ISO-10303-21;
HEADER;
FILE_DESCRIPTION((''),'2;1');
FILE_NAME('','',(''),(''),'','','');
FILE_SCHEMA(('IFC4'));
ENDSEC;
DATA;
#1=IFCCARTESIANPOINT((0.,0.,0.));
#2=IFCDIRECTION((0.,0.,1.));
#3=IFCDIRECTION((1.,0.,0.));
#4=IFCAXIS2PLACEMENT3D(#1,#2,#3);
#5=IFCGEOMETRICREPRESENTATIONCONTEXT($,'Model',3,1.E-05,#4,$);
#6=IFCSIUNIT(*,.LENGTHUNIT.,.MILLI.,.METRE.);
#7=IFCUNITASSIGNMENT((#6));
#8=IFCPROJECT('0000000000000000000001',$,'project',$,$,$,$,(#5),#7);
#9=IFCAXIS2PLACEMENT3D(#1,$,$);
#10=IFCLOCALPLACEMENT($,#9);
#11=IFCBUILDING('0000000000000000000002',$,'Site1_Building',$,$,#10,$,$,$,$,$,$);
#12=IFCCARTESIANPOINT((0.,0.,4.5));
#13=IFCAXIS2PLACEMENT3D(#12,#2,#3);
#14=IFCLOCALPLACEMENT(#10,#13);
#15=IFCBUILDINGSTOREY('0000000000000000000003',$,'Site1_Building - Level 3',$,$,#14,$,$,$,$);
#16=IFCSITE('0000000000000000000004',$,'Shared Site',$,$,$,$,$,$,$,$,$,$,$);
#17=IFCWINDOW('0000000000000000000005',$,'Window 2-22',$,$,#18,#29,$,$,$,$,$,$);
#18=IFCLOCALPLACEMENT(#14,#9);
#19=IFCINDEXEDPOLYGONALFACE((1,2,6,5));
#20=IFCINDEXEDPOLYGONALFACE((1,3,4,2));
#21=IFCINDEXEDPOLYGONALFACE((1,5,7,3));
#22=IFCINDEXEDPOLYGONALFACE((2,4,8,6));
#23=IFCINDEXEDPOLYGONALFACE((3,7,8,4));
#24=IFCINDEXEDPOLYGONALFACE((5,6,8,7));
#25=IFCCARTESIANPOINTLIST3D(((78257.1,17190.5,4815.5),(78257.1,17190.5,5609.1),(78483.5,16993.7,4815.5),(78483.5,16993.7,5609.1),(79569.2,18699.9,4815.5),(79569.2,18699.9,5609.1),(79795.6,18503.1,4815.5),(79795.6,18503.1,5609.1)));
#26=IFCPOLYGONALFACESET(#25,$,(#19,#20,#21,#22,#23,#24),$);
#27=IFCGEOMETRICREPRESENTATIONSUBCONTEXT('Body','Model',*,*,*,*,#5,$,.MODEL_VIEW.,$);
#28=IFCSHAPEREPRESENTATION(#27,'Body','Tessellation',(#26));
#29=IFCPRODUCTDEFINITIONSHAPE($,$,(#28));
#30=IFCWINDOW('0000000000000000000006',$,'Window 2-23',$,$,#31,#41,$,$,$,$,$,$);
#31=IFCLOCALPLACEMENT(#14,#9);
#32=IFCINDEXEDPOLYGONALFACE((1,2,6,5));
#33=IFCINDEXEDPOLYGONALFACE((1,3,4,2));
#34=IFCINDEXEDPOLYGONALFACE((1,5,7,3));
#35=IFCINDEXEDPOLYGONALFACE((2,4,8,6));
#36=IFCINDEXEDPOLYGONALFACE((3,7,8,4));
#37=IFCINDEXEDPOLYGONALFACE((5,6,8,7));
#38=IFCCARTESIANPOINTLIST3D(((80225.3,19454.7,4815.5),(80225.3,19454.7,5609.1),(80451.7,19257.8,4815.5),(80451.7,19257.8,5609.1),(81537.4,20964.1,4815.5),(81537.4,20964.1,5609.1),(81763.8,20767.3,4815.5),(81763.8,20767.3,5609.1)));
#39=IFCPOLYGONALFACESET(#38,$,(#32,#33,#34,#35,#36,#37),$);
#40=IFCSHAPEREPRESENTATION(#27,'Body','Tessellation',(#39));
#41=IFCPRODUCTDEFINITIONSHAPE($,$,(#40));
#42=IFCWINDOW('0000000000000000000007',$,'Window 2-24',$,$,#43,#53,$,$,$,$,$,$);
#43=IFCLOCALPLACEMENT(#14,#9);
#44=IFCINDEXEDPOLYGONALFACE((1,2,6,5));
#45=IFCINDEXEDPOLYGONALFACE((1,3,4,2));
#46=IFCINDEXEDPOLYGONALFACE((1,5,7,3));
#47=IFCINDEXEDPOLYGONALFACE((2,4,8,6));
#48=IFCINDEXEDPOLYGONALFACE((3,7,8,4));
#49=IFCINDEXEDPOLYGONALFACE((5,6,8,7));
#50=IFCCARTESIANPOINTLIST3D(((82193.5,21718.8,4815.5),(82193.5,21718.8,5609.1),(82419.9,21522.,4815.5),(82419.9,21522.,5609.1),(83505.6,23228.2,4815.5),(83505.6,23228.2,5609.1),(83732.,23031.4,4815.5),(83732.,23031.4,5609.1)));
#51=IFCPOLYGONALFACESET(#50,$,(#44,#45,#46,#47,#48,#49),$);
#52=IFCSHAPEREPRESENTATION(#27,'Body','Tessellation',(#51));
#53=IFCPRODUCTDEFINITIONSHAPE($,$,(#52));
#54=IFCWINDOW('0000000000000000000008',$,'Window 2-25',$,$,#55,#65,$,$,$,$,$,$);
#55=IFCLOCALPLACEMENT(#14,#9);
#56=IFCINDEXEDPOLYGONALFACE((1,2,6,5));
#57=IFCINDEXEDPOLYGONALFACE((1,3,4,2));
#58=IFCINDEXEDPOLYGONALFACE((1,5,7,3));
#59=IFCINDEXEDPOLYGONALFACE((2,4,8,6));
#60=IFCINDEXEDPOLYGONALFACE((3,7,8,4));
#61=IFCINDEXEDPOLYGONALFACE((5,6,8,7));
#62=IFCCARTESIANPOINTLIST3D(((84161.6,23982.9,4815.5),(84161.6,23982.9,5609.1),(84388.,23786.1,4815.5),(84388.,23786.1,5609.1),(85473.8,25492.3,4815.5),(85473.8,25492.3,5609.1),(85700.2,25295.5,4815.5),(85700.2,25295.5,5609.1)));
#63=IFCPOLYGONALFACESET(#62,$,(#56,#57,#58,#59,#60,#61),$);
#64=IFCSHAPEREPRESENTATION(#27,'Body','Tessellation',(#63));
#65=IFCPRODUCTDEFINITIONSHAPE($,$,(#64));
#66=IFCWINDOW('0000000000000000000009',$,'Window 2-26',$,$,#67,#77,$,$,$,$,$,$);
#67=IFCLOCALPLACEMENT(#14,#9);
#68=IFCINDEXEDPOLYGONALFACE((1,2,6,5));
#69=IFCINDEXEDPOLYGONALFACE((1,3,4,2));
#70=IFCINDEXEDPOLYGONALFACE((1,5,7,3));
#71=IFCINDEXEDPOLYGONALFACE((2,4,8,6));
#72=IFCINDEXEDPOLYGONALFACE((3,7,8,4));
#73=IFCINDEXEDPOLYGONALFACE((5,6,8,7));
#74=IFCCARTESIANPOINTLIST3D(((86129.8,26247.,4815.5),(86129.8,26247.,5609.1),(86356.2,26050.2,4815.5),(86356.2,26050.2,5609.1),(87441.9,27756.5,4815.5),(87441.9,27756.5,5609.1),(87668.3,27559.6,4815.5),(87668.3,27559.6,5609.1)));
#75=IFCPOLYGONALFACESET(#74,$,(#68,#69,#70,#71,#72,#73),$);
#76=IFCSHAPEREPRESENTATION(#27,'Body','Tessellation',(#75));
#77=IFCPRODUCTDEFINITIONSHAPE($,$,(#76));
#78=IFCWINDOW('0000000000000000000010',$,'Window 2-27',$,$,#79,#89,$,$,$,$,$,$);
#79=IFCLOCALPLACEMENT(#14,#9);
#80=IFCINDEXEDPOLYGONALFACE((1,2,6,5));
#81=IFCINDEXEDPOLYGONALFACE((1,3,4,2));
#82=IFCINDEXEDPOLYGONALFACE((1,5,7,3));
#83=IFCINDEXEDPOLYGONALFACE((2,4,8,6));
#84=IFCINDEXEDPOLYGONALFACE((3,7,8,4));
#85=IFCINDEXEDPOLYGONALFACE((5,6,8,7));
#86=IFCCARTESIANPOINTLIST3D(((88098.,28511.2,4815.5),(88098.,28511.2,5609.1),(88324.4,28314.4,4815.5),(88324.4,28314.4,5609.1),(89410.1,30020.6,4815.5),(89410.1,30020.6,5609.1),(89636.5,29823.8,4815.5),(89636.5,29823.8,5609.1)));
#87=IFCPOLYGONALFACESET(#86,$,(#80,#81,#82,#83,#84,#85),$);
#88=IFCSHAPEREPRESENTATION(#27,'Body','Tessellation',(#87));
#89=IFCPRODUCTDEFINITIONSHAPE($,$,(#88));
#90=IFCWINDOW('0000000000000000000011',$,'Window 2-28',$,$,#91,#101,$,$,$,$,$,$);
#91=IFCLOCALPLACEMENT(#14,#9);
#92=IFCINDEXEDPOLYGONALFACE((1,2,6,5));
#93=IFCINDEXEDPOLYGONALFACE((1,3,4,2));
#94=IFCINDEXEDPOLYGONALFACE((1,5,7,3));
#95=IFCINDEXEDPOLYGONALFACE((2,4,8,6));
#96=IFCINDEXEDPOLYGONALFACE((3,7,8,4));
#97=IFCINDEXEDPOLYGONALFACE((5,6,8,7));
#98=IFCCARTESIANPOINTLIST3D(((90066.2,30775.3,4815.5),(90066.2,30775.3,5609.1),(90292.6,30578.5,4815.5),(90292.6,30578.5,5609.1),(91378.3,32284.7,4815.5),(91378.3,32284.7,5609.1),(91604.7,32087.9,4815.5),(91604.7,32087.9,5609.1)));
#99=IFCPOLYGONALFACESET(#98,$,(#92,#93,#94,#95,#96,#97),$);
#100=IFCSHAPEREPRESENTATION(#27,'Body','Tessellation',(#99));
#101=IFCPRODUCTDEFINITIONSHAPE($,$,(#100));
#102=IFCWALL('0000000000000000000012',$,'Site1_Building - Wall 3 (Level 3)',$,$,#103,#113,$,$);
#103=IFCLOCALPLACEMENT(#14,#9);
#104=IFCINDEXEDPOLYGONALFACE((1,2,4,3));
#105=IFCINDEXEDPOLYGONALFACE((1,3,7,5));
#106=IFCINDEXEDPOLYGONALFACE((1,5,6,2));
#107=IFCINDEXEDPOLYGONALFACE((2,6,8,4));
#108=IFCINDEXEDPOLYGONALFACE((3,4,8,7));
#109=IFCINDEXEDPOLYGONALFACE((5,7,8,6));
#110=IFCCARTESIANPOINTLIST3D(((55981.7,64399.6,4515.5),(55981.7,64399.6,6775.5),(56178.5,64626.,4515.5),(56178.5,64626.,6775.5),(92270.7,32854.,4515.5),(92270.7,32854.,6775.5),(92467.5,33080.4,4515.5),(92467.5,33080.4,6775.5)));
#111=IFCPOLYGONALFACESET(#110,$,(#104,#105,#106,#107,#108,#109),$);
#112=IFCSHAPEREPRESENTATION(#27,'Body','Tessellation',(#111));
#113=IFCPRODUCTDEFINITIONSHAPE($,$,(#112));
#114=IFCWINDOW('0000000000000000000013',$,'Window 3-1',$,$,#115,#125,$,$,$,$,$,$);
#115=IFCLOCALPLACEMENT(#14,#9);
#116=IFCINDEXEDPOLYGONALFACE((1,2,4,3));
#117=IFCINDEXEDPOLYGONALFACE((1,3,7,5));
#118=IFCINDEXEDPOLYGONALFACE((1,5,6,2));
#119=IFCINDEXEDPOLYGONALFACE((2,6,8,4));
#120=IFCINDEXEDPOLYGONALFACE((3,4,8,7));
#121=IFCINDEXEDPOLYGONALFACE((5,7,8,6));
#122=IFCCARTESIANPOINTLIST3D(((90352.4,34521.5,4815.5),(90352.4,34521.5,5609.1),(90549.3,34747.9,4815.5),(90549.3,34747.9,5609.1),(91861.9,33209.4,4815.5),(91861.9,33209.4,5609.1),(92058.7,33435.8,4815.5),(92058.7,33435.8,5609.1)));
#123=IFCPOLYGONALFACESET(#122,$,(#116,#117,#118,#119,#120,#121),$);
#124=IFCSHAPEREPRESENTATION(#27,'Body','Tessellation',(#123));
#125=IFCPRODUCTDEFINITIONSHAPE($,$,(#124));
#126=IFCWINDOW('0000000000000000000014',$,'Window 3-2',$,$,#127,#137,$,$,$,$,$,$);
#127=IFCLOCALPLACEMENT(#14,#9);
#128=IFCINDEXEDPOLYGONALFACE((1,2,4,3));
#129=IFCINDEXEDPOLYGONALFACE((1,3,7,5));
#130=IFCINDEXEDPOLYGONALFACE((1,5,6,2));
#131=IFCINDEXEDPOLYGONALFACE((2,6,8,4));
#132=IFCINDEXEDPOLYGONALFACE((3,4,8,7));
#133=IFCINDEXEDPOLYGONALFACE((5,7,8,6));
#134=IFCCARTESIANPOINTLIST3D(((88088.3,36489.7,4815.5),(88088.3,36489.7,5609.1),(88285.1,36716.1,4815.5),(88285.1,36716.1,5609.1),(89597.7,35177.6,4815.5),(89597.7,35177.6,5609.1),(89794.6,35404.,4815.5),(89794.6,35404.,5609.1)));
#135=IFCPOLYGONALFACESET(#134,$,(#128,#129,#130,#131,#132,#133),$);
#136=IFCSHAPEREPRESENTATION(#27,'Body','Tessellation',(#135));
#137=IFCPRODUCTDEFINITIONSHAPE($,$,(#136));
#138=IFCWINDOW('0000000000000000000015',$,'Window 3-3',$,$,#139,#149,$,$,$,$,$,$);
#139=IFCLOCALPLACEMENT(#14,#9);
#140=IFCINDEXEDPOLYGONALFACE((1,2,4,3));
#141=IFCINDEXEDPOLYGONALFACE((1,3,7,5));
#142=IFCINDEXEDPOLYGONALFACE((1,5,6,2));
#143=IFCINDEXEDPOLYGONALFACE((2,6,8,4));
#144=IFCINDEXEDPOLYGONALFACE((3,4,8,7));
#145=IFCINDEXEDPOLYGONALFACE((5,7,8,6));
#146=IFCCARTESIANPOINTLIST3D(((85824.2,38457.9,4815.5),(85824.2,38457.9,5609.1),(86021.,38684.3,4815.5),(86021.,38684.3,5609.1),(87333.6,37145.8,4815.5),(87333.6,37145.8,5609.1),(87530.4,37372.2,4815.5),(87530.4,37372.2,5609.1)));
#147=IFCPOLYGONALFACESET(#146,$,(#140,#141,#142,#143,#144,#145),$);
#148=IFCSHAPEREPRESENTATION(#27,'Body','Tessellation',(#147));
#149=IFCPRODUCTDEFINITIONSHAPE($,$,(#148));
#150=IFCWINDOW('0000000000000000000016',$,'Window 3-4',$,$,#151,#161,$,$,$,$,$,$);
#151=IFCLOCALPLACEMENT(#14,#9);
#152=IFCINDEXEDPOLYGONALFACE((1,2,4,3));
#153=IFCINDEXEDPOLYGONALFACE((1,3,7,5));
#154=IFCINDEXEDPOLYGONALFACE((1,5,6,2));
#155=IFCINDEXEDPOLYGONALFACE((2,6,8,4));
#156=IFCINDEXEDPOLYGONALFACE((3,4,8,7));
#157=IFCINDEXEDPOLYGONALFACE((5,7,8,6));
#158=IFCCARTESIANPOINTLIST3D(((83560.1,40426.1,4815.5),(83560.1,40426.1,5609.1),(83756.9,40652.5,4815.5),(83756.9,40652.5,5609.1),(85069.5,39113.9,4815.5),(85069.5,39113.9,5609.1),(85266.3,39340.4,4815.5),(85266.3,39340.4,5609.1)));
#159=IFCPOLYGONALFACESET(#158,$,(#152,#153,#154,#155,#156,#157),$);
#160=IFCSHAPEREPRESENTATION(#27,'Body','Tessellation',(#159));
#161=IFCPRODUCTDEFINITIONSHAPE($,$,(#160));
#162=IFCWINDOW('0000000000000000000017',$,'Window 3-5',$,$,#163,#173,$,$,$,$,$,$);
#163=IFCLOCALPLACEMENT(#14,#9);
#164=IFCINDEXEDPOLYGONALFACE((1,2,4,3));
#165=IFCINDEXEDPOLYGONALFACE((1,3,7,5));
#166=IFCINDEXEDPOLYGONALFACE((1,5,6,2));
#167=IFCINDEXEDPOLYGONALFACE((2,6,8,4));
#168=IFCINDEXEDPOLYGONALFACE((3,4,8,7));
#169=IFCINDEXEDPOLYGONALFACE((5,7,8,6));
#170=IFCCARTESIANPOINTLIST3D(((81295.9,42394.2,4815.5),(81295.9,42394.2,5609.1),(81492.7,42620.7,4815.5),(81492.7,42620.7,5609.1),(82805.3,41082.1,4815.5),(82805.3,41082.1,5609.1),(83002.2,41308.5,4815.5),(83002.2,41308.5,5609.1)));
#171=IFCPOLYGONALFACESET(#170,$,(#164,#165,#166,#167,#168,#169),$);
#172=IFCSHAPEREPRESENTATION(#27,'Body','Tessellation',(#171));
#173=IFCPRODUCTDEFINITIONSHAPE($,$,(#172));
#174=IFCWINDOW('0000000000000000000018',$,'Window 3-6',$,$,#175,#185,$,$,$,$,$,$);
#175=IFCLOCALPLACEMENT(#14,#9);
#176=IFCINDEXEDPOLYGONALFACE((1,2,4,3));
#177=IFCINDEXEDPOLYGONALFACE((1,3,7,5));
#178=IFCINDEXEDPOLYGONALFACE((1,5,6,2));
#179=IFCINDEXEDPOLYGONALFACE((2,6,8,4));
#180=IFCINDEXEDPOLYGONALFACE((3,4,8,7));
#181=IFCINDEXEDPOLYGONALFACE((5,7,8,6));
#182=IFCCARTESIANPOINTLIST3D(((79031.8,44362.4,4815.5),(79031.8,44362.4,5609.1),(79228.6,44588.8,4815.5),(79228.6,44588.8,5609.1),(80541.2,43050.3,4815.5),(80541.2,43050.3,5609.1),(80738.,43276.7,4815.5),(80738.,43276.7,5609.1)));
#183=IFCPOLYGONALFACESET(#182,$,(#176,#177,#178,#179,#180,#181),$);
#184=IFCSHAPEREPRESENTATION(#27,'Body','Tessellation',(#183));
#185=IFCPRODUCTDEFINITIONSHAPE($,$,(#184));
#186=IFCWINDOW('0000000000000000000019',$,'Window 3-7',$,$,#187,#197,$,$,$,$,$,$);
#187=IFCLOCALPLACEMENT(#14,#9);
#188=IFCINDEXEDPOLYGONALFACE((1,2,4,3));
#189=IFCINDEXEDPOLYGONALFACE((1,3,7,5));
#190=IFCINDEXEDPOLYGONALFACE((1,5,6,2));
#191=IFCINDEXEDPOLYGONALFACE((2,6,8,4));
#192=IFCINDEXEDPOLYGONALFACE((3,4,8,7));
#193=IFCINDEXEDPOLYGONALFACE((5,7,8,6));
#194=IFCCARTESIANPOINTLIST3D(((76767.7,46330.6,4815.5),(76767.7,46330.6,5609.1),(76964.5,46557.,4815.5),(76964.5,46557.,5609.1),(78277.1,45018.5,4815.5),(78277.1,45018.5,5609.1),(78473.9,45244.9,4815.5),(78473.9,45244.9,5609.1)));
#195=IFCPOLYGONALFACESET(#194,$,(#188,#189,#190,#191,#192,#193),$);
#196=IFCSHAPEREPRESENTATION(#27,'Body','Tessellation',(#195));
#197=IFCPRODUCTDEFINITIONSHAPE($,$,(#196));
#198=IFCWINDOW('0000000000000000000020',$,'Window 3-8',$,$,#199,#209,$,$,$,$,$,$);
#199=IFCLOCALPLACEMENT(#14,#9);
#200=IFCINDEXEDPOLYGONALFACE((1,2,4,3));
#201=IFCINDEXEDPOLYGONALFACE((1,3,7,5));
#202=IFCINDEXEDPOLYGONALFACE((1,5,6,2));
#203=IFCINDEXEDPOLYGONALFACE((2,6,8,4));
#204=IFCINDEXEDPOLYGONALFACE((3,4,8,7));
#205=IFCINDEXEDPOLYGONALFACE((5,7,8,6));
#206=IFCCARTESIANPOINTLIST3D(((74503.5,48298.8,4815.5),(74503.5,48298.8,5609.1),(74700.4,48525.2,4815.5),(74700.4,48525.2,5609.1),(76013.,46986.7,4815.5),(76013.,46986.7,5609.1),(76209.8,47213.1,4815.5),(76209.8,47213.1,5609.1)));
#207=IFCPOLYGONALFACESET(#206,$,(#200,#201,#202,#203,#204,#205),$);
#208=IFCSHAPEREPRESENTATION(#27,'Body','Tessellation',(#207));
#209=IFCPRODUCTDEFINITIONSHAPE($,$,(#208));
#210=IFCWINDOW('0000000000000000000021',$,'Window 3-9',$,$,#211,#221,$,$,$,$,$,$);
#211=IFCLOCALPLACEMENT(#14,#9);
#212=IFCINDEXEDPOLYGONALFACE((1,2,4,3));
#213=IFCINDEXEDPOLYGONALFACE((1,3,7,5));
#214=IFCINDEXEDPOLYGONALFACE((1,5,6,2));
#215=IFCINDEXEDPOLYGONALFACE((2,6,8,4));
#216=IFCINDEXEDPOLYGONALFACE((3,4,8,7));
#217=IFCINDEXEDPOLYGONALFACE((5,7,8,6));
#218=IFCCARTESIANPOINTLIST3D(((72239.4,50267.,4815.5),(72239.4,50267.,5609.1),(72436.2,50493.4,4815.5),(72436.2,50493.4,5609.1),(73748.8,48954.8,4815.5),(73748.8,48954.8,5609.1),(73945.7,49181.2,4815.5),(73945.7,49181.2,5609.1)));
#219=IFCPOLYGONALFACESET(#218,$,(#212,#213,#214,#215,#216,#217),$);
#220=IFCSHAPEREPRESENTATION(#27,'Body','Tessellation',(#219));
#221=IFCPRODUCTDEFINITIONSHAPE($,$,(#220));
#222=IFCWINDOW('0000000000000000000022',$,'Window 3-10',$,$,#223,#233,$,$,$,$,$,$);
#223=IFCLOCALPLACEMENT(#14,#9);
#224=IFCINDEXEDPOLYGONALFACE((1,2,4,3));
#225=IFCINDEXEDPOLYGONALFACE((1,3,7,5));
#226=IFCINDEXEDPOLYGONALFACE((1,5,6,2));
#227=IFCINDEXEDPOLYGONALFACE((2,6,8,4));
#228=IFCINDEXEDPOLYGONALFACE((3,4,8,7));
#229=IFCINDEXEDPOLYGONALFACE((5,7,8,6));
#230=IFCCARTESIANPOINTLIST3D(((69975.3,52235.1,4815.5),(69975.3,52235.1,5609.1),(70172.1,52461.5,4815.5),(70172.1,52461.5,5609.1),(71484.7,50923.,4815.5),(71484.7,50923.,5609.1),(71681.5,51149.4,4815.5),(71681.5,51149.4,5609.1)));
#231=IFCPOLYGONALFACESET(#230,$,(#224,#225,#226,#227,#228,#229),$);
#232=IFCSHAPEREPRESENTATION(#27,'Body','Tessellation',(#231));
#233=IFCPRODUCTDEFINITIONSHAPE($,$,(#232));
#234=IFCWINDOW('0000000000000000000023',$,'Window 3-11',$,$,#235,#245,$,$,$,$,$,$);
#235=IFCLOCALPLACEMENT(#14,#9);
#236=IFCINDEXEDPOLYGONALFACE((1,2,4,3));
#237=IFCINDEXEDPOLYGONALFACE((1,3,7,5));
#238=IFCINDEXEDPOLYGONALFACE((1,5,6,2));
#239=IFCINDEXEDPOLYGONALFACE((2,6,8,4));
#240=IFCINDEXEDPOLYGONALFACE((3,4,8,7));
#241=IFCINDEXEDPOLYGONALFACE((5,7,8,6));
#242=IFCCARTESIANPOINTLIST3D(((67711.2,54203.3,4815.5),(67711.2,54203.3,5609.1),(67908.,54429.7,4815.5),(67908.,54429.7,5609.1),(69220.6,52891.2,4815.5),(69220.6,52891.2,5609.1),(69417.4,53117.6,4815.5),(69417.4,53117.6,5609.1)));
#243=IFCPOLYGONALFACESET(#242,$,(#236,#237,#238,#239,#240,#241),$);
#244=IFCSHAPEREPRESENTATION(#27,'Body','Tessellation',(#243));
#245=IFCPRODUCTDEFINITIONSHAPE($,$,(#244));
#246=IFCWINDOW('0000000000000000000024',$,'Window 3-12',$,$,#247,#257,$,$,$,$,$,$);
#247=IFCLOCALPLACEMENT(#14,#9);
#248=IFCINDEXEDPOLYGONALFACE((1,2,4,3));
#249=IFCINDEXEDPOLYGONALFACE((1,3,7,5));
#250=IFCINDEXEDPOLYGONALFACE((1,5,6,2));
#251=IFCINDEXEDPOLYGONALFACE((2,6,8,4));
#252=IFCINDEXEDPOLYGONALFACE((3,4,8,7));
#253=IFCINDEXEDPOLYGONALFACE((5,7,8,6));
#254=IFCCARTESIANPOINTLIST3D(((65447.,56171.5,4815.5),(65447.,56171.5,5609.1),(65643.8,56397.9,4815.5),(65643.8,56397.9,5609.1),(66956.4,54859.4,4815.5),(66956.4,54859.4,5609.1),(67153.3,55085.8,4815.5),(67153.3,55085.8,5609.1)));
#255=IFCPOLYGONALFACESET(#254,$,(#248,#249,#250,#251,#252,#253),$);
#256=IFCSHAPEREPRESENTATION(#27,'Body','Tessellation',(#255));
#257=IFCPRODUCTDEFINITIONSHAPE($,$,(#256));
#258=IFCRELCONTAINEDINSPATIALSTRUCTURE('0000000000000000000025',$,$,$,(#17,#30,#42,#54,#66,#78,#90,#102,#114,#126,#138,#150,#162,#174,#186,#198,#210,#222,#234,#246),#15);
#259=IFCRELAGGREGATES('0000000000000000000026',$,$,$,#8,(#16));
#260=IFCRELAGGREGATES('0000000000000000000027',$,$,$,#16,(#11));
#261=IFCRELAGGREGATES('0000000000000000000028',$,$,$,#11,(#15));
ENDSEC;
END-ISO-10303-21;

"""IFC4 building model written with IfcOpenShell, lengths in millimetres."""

from ifc_helpers import new_model, si_unit, frame, origin, origin_with_axes, place, context, subcontext, project, spatial, indexed_curve, outline, extrude, element, save


model = new_model("IFC4")

# Units and contexts
model_context = context("Model", 3, precision=1e-05, world=origin_with_axes())
body_context = subcontext(model_context, "Body", "Model", "MODEL_VIEW")
ifc_project = project(units=[si_unit("LENGTHUNIT", "METRE", prefix="MILLI")], contexts=[model_context])

# Site, building, storey
site = spatial("IfcSite", under=ifc_project, Name="Shared Site")
building_placement = place(None, origin())
building = spatial("IfcBuilding", under=site, at=building_placement, Name="Site1_Building")
storey_placement = place(building_placement, frame((0.0, 0.0, 4.5), z_axis=(0.0, 0.0, 1.0), x_axis=(1.0, 0.0, 0.0)))
storey = spatial("IfcBuildingStorey", under=building, at=storey_placement, Name="Site1_Building - Level 3")

# Windows
for number, where, z_axis, x_axis, name in (
    (1, (78483.5, 16993.7, 4815.5), (0.0, 0.0, 1.0), (0.656059, 0.75471, 0.0), "Window 2-22"),
    (2, (80451.7, 19257.8, 4815.5), (0.0, 0.0, 1.0), (0.656059, 0.75471, 0.0), "Window 2-23"),
    (3, (82419.9, 21522.0, 4815.5), (0.0, 0.0, 1.0), (0.656059, 0.75471, 0.0), "Window 2-24"),
    (4, (84388.0, 23786.1, 4815.5), (0.0, 0.0, 1.0), (0.656059, 0.75471, 0.0), "Window 2-25"),
    (5, (86356.2, 26050.2, 4815.5), (0.0, 0.0, 1.0), (0.656059, 0.75471, 0.0), "Window 2-26"),
    (6, (88324.4, 28314.4, 4815.5), (0.0, 0.0, 1.0), (0.656059, 0.75471, 0.0), "Window 2-27"),
    (7, (90292.6, 30578.5, 4815.5), (0.0, 0.0, 1.0), (0.656059, 0.75471, 0.0), "Window 2-28"),
):
    element("IfcWindow", number, at=place(storey_placement, frame(where, z_axis=z_axis, x_axis=x_axis)), inside=storey, Name=name, context=body_context, shape_type="SweptSolid", body=[
        extrude(outline(indexed_curve([(0.0, 0.0), (0.0, 300.0), (2000.0, 300.0), (2000.0, 0.0), (0.0, 0.0)], self_intersect=False)), origin_with_axes(), (0.0, 0.0, 1.0), 793.6),
    ])

# Wall
wall_placement = place(storey_placement, frame((92467.5, 33080.4, 4515.5), z_axis=(0.0, 0.0, 1.0), x_axis=(-0.75471, 0.656059, 0.0)))
element("IfcWall", 8, at=wall_placement, inside=storey, Name="Site1_Building - Wall 3 (Level 3)", context=body_context, shape_type="SweptSolid", body=[
    extrude(outline(indexed_curve([(0.0, 0.0), (0.0, 300.0), (48083.4, 300.0), (48083.4, 0.0), (0.0, 0.0)], self_intersect=False)), origin_with_axes(), (0.0, 0.0, 1.0), 2260.0),
])

# Windows
for number, where, z_axis, x_axis, name in (
    (9, (92058.7, 33435.8, 4815.5), (0.0, 0.0, 1.0), (-0.75471, 0.656059, 0.0), "Window 3-1"),
    (10, (89794.6, 35404.0, 4815.5), (0.0, 0.0, 1.0), (-0.75471, 0.656059, 0.0), "Window 3-2"),
    (11, (87530.4, 37372.2, 4815.5), (0.0, 0.0, 1.0), (-0.75471, 0.656059, 0.0), "Window 3-3"),
    (12, (85266.3, 39340.4, 4815.5), (0.0, 0.0, 1.0), (-0.75471, 0.656059, 0.0), "Window 3-4"),
    (13, (83002.2, 41308.5, 4815.5), (0.0, 0.0, 1.0), (-0.75471, 0.656059, 0.0), "Window 3-5"),
    (14, (80738.0, 43276.7, 4815.5), (0.0, 0.0, 1.0), (-0.75471, 0.656059, 0.0), "Window 3-6"),
    (15, (78473.9, 45244.9, 4815.5), (0.0, 0.0, 1.0), (-0.75471, 0.656059, 0.0), "Window 3-7"),
    (16, (76209.8, 47213.1, 4815.5), (0.0, 0.0, 1.0), (-0.75471, 0.656059, 0.0), "Window 3-8"),
    (17, (73945.7, 49181.2, 4815.5), (0.0, 0.0, 1.0), (-0.75471, 0.656059, 0.0), "Window 3-9"),
    (18, (71681.5, 51149.4, 4815.5), (0.0, 0.0, 1.0), (-0.75471, 0.656059, 0.0), "Window 3-10"),
    (19, (69417.4, 53117.6, 4815.5), (0.0, 0.0, 1.0), (-0.75471, 0.656059, 0.0), "Window 3-11"),
    (20, (67153.3, 55085.8, 4815.5), (0.0, 0.0, 1.0), (-0.75471, 0.656059, 0.0), "Window 3-12"),
):
    element("IfcWindow", number, at=place(storey_placement, frame(where, z_axis=z_axis, x_axis=x_axis)), inside=storey, Name=name, context=body_context, shape_type="SweptSolid", body=[
        extrude(outline(indexed_curve([(0.0, 0.0), (0.0, 300.0), (2000.0, 300.0), (2000.0, 0.0), (0.0, 0.0)], self_intersect=False)), origin_with_axes(), (0.0, 0.0, 1.0), 793.6),
    ])

save(model, "model.ifc")
